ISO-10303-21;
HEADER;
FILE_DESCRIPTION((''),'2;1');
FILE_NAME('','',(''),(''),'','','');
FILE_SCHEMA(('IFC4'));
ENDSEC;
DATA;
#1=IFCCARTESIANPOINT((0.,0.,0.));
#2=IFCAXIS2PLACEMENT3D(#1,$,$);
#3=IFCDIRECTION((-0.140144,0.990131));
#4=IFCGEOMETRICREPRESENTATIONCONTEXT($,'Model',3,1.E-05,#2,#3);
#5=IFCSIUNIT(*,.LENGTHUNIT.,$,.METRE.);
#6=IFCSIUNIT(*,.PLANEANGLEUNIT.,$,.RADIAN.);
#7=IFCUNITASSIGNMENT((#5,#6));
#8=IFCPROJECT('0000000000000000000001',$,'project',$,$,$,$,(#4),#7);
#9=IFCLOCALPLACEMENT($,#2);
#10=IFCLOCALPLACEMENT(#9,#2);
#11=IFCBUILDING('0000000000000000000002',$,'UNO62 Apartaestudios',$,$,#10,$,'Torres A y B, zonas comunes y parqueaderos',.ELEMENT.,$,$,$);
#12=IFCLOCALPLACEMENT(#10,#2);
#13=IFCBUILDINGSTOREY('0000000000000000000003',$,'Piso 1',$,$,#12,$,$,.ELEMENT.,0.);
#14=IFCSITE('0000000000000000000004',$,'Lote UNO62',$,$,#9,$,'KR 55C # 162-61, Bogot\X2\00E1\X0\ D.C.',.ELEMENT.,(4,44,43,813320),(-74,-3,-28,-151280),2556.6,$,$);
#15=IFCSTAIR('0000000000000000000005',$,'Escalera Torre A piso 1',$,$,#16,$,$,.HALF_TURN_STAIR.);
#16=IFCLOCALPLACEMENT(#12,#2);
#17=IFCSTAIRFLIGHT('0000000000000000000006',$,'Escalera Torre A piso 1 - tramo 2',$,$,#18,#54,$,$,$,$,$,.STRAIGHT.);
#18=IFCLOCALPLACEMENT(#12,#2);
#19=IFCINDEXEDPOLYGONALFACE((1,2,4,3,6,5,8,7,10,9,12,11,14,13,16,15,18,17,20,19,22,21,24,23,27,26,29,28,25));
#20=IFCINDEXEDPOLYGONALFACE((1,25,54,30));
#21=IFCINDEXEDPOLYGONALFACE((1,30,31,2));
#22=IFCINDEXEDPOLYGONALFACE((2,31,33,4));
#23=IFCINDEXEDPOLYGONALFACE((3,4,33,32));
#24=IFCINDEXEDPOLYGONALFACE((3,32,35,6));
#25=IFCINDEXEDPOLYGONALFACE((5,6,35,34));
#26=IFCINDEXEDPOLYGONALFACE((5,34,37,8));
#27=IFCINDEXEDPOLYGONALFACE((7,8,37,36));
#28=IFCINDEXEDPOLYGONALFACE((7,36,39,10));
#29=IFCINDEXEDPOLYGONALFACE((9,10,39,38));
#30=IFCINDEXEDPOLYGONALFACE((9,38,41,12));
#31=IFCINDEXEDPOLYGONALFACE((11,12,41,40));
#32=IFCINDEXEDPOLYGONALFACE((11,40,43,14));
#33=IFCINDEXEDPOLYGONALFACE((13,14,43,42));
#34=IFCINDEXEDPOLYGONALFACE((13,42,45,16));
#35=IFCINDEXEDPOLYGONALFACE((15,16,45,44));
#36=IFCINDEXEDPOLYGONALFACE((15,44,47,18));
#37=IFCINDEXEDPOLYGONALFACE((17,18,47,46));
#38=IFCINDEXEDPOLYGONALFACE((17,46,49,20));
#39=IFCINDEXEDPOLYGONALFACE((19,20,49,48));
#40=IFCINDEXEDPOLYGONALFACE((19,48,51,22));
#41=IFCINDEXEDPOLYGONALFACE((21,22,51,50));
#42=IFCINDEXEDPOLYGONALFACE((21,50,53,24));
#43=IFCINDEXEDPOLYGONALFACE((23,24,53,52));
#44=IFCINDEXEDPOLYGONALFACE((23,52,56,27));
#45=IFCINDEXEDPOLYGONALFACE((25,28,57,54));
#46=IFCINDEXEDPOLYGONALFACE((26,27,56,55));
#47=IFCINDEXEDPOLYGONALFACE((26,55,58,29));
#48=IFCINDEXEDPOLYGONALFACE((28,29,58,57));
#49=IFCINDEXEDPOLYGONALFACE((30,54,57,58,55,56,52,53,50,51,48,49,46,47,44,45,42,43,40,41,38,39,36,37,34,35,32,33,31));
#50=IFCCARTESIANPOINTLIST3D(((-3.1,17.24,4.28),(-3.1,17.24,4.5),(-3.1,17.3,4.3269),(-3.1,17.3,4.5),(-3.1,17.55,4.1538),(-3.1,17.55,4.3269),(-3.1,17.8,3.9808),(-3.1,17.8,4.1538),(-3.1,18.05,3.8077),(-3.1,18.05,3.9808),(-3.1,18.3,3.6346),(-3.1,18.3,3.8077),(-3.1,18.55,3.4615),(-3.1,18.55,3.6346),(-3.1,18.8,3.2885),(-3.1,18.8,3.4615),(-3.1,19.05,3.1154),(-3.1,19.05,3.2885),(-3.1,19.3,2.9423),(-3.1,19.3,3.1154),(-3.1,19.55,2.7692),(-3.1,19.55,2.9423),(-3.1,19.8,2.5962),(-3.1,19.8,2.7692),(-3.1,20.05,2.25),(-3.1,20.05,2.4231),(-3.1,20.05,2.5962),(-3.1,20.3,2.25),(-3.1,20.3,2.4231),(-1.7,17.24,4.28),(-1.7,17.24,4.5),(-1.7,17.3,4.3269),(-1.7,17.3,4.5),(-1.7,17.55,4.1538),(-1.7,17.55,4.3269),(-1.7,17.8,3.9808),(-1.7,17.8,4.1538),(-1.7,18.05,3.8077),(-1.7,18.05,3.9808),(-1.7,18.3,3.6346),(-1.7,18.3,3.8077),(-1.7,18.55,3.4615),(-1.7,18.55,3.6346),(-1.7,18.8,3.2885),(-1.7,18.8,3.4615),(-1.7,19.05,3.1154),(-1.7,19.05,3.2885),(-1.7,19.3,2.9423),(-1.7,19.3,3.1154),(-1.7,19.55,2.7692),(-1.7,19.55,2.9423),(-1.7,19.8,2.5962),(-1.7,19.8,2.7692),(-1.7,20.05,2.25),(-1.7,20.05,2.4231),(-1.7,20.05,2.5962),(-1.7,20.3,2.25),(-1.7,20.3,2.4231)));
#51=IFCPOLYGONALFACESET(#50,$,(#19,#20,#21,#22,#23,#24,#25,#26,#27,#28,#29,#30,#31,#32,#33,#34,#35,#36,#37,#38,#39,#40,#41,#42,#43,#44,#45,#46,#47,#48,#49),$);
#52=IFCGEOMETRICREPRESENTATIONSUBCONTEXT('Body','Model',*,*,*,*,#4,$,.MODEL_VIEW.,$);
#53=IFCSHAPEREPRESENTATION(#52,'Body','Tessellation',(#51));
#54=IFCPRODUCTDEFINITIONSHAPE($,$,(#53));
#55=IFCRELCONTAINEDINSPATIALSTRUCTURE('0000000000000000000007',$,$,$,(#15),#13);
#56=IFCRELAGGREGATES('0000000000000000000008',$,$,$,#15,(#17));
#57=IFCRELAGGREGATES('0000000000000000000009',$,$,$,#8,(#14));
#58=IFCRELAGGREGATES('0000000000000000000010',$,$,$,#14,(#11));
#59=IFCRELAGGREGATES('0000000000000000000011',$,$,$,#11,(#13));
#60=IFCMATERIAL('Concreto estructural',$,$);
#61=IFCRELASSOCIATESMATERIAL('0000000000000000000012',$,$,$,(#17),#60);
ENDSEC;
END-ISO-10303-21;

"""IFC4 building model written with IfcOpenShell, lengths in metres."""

from ifc_helpers import new_model, si_unit, direction, frame, origin, place, context, subcontext, project, spatial, polyline, outline, extrude, material, element, aggregate, save


model = new_model("IFC4")

# Units and contexts
model_context = context("Model", 3, precision=1e-05, world=origin(), true_north=direction((-0.140144, 0.990131)))
body_context = subcontext(model_context, "Body", "Model", "MODEL_VIEW")
ifc_project = project(units=[si_unit("LENGTHUNIT", "METRE"), si_unit("PLANEANGLEUNIT", "RADIAN")], contexts=[model_context])

# Site, building, storey
site_placement = place(None, origin())
site = spatial("IfcSite", under=ifc_project, at=site_placement, Name="Lote UNO62", LongName="KR 55C # 162-61, Bogotá D.C.", CompositionType="ELEMENT", RefLatitude=(4, 44, 43, 813320), RefLongitude=(-74, -3, -28, -151280), RefElevation=2556.6)
building_placement = place(site_placement, origin())
building = spatial("IfcBuilding", under=site, at=building_placement, Name="UNO62 Apartaestudios", LongName="Torres A y B, zonas comunes y parqueaderos", CompositionType="ELEMENT")
storey_placement = place(building_placement, origin())
storey = spatial("IfcBuildingStorey", under=building, at=storey_placement, Name="Piso 1", CompositionType="ELEMENT", Elevation=0.0)

# Stair
stair_placement = place(storey_placement, origin())
stair = element("IfcStair", 1, at=stair_placement, inside=storey, Name="Escalera Torre A piso 1", PredefinedType="HALF_TURN_STAIR")
ifc_material_1 = material(Name="Concreto estructural")

# Stair flight
stair_flight_1_placement = place(storey_placement, origin())
stair_flight_1 = element("IfcStairFlight", 2, at=stair_flight_1_placement, material=ifc_material_1, Name="Escalera Torre A piso 1 - tramo 2", PredefinedType="STRAIGHT", context=body_context, shape_type="SweptSolid", body=[
    extrude(outline(polyline([(0.0, 0.0), (0.0, 0.1731), (0.25, 0.1731), (0.25, 0.3462), (0.5, 0.3462), (0.5, 0.5192), (0.75, 0.5192), (0.75, 0.6923), (1.0, 0.6923), (1.0, 0.8654), (1.25, 0.8654), (1.25, 1.0385), (1.5, 1.0385), (1.5, 1.2115), (1.75, 1.2115), (1.75, 1.3846), (2.0, 1.3846), (2.0, 1.5577), (2.25, 1.5577), (2.25, 1.7308), (2.5, 1.7308), (2.5, 1.9038), (2.75, 1.9038), (2.75, 2.0769), (3.0, 2.0769), (3.0, 2.25), (3.06, 2.25), (3.06, 2.03), (0.25, 0.0), (0.0, 0.0)])), frame((-1.7, 20.3, 2.25), z_axis=(-1.0, 0.0, 0.0), x_axis=(0.0, -1.0, 0.0)), (0.0, 0.0, 1.0), 1.4),
])
aggregate(stair, [stair_flight_1])

save(model, "model.ifc")
